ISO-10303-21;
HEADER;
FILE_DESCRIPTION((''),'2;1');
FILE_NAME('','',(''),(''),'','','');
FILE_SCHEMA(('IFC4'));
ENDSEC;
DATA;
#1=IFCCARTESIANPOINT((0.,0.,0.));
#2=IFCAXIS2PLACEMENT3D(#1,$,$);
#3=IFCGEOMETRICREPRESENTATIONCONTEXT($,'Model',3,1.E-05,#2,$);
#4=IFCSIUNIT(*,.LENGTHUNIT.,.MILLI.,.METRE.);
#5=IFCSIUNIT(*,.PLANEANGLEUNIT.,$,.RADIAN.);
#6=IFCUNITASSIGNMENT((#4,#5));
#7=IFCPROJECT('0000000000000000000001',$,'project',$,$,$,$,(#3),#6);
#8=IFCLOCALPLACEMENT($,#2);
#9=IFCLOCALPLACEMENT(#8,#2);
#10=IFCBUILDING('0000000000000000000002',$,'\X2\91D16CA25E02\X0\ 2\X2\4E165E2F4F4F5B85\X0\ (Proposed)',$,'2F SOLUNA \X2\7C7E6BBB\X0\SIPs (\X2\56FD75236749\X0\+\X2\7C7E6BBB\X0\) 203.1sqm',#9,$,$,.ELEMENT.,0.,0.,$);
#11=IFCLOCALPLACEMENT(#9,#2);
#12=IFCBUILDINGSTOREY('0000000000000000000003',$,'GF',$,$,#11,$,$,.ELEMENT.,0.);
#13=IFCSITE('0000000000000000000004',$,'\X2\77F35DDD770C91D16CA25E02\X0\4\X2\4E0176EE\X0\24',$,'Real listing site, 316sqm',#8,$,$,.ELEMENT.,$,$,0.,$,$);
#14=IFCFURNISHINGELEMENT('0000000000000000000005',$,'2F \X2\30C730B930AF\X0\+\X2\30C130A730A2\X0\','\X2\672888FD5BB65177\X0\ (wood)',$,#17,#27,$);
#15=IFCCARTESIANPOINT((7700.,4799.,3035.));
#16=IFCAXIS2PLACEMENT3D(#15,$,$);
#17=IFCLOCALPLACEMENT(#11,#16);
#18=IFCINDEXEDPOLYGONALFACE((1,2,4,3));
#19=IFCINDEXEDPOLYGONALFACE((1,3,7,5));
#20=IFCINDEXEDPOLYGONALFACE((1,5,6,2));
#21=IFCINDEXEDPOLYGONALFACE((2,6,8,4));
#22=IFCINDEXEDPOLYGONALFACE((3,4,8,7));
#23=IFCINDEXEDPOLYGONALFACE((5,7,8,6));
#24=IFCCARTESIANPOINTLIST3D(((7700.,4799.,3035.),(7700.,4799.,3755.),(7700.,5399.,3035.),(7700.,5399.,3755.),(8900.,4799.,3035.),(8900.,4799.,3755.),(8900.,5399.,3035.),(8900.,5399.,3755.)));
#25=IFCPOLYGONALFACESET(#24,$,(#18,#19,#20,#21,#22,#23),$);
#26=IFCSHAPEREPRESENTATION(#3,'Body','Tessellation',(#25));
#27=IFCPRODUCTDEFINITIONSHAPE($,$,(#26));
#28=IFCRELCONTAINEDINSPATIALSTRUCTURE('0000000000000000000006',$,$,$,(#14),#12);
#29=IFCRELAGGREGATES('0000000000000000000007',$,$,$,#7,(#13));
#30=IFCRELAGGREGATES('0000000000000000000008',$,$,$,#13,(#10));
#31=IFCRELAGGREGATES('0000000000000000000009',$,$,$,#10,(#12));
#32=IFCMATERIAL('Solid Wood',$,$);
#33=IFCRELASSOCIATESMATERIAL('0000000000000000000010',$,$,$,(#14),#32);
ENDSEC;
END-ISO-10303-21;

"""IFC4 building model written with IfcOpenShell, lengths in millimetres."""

from ifc_helpers import new_model, si_unit, frame, frame_2d, origin, place, context, project, spatial, rectangle, extrude, material, element, save


model = new_model("IFC4")

# Units and contexts
model_context = context("Model", 3, precision=1e-05, world=origin())
ifc_project = project(units=[si_unit("LENGTHUNIT", "METRE", prefix="MILLI"), si_unit("PLANEANGLEUNIT", "RADIAN")], contexts=[model_context])

# Site, building, storey
site_placement = place(None, origin())
site = spatial("IfcSite", under=ifc_project, at=site_placement, Name="石川県金沢市4丁目24", ObjectType="Real listing site, 316sqm", CompositionType="ELEMENT", RefElevation=0.0)
building_placement = place(site_placement, origin())
building = spatial("IfcBuilding", under=site, at=building_placement, Name="金沢市 2世帯住宅 (Proposed)", ObjectType="2F SOLUNA 籾殻SIPs (国産杉+籾殻) 203.1sqm", CompositionType="ELEMENT", ElevationOfRefHeight=0.0, ElevationOfTerrain=0.0)
storey_placement = place(building_placement, origin())
storey = spatial("IfcBuildingStorey", under=building, at=storey_placement, Name="GF", CompositionType="ELEMENT", Elevation=0.0)

# Shared definitions
ifc_material_1 = material(Name="Solid Wood")

# Furnishing element
furnishing_1_placement = place(storey_placement, frame((7700.0, 4799.0, 3035.0)))
element("IfcFurnishingElement", 1, at=furnishing_1_placement, inside=storey, material=ifc_material_1, Name="2F デスク+チェア", Description="木製家具 (wood)", context=model_context, shape_type="SweptSolid", body=[
    extrude(rectangle(XDim=1200.0, YDim=600.0, at=frame_2d((600.0, 300.0))), frame((7700.0, 4799.0, 3035.0)), (0.0, 0.0, 1.0), 720.0),
])

save(model, "model.ifc")
